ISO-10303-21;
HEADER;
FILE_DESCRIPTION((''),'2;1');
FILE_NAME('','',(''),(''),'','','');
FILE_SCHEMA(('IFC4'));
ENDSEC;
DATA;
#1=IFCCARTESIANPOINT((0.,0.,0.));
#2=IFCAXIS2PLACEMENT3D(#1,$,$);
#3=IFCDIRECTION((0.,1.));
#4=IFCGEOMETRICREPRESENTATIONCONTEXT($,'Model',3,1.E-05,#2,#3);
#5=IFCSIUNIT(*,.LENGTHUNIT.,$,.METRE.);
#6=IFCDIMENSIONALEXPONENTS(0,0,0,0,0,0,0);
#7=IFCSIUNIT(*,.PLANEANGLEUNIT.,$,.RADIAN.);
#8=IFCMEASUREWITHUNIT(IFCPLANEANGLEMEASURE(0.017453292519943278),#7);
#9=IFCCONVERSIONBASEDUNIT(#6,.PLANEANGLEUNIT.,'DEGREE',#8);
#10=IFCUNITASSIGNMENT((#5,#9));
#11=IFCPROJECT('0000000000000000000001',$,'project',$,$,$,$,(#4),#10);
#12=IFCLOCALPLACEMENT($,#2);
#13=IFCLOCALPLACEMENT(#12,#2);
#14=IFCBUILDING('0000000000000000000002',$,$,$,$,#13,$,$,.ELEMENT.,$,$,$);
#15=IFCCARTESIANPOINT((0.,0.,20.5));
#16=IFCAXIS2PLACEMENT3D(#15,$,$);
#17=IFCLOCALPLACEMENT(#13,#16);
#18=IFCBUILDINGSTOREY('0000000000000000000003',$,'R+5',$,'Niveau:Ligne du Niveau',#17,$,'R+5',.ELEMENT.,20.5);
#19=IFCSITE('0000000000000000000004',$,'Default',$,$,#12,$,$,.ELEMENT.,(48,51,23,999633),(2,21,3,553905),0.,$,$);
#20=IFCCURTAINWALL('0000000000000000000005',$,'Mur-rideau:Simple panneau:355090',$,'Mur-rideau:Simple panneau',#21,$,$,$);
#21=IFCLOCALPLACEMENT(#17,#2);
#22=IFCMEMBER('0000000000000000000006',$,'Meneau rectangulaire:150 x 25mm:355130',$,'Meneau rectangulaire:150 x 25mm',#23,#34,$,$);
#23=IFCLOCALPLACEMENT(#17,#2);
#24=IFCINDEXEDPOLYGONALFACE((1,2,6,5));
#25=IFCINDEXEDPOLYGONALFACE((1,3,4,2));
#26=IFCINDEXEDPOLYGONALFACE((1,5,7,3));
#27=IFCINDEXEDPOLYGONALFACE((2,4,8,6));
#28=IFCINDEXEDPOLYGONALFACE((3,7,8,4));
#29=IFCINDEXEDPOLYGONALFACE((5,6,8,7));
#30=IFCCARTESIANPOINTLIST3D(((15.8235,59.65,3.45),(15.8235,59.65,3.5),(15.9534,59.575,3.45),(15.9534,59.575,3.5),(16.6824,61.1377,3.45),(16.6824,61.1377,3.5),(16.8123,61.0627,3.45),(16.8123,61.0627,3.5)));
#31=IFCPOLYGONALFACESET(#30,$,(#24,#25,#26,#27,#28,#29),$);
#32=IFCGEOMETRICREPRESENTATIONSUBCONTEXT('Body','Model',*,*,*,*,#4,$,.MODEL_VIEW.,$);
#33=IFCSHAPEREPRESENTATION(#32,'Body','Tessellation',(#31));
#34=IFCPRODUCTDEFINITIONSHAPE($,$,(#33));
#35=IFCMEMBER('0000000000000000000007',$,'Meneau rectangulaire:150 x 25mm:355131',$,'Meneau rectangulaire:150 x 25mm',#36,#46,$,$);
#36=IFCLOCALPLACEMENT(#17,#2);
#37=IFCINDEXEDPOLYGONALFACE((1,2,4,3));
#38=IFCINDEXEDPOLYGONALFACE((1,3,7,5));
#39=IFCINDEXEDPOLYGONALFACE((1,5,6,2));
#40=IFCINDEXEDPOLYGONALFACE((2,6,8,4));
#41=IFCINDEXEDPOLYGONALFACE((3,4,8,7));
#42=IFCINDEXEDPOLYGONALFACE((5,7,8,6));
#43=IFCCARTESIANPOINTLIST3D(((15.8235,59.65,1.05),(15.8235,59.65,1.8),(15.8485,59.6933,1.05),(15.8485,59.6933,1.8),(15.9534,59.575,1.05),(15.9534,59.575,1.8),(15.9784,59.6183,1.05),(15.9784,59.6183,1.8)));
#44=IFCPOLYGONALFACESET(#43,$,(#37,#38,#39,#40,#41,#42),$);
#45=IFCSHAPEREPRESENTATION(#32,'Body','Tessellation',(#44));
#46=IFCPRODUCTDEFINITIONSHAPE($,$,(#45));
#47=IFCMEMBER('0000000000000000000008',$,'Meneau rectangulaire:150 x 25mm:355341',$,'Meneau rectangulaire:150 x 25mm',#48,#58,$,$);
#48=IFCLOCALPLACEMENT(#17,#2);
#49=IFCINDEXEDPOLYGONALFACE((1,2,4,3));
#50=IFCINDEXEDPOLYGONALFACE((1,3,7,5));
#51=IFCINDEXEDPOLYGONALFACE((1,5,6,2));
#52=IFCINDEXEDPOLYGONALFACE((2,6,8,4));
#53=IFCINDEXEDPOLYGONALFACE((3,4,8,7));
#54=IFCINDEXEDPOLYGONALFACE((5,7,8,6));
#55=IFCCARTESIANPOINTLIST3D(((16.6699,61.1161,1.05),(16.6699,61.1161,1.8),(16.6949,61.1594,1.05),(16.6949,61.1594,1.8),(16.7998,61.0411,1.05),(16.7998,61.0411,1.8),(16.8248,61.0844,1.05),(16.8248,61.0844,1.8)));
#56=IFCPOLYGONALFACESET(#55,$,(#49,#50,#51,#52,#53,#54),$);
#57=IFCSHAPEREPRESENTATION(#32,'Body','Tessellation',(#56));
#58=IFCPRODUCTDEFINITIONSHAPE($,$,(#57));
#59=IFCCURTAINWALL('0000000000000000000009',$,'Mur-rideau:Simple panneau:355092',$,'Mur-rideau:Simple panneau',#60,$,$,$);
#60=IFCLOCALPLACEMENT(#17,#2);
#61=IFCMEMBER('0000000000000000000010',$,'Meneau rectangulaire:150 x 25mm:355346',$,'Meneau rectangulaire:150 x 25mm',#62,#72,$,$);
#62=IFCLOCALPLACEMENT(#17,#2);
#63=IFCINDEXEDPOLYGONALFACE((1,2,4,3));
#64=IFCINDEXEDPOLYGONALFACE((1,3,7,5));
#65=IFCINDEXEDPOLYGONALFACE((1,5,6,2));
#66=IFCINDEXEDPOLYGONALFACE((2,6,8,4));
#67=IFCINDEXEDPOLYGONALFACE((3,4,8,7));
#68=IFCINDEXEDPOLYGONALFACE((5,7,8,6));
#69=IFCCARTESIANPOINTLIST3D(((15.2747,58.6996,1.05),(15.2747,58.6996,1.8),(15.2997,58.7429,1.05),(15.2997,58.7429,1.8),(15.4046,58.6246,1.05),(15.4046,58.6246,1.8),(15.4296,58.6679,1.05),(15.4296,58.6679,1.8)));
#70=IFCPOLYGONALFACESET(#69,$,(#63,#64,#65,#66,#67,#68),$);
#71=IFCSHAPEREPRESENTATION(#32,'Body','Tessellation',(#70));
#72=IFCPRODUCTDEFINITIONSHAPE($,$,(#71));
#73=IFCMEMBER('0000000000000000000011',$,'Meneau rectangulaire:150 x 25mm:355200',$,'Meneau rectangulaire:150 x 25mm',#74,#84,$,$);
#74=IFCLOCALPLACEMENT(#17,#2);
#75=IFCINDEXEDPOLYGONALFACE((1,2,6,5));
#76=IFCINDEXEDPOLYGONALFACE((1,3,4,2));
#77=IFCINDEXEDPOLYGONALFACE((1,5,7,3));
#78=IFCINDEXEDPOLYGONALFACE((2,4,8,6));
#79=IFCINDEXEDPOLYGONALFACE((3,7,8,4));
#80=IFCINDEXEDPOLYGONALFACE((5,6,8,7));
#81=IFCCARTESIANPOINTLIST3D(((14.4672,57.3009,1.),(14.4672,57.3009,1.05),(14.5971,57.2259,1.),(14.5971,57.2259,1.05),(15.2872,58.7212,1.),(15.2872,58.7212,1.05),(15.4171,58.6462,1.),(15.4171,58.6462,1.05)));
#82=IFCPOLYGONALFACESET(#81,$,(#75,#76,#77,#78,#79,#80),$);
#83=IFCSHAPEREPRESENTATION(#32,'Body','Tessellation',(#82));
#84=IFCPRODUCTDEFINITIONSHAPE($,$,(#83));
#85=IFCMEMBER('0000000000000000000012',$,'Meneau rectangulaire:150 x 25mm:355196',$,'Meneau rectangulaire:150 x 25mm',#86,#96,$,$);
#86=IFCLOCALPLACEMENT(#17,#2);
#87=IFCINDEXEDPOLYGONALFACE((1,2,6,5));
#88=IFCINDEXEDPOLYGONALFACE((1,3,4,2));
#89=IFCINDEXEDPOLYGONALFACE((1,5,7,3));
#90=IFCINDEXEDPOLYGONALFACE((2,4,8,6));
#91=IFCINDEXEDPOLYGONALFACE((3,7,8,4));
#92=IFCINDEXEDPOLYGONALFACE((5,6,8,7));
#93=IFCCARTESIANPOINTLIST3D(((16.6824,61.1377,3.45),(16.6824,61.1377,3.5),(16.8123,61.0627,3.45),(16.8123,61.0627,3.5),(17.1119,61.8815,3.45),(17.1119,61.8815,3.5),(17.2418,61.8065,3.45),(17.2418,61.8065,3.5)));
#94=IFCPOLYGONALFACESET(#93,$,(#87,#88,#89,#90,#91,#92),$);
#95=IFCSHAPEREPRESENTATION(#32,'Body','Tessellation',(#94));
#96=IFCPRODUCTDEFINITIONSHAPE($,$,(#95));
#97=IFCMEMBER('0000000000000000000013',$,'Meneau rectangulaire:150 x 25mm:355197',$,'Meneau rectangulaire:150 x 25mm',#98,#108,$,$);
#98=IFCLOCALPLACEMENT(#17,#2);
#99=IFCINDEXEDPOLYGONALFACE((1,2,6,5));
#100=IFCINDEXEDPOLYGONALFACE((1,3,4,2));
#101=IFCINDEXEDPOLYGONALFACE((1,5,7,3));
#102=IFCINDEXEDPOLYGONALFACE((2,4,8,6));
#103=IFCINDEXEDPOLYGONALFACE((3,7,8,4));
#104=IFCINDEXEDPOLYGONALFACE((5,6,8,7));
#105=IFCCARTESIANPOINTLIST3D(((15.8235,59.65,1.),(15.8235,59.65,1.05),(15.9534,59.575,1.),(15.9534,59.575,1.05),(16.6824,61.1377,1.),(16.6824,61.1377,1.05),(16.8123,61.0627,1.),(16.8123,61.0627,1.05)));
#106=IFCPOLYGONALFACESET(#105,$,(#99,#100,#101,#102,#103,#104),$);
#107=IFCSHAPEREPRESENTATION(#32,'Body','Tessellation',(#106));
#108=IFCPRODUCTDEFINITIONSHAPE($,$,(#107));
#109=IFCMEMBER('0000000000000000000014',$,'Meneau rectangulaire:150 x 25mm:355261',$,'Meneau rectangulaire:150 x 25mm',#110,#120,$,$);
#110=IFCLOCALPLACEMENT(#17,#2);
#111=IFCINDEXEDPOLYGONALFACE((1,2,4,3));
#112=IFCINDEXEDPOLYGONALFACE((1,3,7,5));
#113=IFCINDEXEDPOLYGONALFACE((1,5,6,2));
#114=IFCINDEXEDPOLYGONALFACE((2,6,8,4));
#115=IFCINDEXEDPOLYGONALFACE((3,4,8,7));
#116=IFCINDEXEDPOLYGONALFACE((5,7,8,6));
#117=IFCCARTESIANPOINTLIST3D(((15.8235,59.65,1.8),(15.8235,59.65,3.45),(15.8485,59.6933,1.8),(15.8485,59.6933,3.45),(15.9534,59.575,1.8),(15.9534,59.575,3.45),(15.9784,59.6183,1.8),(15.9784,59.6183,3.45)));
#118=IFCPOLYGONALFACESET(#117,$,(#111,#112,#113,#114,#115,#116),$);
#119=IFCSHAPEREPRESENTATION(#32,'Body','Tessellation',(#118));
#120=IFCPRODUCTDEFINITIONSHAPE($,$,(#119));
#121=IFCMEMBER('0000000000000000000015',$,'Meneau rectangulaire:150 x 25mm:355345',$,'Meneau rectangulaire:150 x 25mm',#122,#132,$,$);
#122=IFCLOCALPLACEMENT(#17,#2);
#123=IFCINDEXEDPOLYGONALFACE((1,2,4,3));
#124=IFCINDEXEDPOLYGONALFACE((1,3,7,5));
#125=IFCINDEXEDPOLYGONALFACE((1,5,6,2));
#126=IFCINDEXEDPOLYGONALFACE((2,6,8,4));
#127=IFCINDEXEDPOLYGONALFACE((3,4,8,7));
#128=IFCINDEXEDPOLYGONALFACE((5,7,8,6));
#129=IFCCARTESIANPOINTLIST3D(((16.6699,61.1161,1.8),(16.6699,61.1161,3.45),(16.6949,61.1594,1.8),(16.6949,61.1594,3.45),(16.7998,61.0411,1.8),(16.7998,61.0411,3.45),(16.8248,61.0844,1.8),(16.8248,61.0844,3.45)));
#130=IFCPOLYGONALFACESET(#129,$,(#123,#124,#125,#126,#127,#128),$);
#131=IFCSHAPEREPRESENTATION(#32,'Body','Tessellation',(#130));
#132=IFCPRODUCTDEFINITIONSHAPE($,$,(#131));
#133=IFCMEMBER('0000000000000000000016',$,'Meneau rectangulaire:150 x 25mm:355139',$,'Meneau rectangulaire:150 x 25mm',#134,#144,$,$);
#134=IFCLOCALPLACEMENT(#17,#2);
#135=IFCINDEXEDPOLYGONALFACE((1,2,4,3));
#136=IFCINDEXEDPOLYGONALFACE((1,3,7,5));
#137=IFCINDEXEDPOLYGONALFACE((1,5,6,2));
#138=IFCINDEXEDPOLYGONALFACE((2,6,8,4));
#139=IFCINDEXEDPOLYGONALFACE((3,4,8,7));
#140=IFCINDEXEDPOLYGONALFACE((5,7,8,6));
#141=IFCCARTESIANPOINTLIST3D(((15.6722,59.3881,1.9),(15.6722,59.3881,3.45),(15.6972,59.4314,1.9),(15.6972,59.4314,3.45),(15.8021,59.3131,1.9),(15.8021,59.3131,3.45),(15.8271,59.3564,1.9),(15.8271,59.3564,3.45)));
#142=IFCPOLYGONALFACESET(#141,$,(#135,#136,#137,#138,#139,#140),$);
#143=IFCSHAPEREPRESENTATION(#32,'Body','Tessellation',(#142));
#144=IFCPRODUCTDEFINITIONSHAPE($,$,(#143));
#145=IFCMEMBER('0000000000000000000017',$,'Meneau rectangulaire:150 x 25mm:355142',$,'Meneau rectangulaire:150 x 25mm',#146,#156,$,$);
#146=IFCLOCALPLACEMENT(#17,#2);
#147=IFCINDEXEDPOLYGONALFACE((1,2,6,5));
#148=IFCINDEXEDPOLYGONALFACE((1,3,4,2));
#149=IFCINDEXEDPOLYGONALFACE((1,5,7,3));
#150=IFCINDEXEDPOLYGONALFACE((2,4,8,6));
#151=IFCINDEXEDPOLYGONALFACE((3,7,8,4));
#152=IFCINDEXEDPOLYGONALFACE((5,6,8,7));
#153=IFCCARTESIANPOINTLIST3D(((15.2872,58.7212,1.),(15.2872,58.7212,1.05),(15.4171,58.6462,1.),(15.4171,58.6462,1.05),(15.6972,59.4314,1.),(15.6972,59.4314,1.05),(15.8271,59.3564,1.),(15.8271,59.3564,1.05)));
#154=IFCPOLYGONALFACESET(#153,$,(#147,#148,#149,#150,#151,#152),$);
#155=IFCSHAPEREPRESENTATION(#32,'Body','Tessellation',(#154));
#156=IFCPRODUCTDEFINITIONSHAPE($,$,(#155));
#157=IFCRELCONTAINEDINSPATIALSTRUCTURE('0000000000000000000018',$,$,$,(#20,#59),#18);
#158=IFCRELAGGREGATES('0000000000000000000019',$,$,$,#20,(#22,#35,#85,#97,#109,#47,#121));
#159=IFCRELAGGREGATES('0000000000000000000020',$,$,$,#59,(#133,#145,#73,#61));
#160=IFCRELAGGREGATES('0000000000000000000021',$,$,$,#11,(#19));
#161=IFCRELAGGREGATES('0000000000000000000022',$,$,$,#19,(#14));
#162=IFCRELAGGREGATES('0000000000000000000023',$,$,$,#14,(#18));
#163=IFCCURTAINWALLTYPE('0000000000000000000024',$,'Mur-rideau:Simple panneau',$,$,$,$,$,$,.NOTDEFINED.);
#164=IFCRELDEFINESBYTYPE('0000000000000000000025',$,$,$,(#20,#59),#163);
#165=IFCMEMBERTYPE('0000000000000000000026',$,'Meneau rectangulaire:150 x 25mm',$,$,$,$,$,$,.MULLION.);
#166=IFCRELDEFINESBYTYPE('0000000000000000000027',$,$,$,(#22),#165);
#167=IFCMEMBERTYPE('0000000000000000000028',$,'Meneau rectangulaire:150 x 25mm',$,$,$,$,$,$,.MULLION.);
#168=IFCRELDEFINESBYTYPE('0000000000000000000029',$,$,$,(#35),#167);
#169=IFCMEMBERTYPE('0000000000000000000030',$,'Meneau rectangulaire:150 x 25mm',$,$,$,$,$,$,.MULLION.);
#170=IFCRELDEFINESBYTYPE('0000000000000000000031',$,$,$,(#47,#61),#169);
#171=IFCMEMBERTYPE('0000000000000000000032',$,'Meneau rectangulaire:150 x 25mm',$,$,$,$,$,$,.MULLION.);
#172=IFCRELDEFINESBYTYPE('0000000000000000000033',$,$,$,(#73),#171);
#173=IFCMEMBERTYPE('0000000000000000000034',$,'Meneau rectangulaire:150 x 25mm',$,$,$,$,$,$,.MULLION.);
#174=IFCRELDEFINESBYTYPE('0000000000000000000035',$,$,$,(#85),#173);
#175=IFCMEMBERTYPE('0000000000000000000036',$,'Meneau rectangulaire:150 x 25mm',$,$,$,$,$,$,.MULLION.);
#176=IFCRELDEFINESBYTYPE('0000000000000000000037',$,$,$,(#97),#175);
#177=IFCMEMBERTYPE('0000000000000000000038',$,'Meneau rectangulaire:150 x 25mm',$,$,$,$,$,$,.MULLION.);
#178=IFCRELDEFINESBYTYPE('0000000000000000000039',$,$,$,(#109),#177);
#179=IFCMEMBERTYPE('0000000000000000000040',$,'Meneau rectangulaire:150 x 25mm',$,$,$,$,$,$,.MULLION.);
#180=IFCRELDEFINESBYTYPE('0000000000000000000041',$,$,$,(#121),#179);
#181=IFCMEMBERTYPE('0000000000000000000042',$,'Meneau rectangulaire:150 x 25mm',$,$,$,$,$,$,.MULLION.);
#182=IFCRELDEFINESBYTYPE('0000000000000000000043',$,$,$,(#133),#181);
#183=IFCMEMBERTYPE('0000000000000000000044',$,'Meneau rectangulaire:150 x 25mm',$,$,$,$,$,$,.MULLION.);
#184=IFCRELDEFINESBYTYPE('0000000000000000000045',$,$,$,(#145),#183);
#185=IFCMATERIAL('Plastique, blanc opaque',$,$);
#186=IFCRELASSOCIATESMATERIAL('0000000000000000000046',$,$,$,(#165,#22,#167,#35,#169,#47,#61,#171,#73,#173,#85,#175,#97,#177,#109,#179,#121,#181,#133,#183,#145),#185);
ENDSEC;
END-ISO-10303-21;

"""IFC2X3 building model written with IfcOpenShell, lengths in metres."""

from ifc_helpers import new_model, entity, si_unit, converted_unit, direction, frame, frame_2d, origin, origin_2d_with_axis, place, context, subcontext, project, spatial, rectangle, extrude, source, transform, mapped, material, type_object, type_shapes, element, aggregate, save


model = new_model("IFC2X3")

# Units and contexts
model_context = context("Model", 3, precision=1e-05, world=origin(), true_north=direction((0.0, 1.0)))
body_context = subcontext(model_context, "Body", "Model", "MODEL_VIEW")
ifc_project = project(units=[si_unit("LENGTHUNIT", "METRE"), converted_unit("PLANEANGLEUNIT", "DEGREE", entity("IfcPlaneAngleMeasure", 0.017453292519943278), si_unit("PLANEANGLEUNIT", "RADIAN"), dimensions=[0, 0, 0, 0, 0, 0, 0])], contexts=[model_context])

# Site, building, storey
site_placement = place(None, origin())
site = spatial("IfcSite", under=ifc_project, at=site_placement, Name="Default", CompositionType="ELEMENT", RefLatitude=(48, 51, 23, 999633), RefLongitude=(2, 21, 3, 553905), RefElevation=0.0)
building_placement = place(site_placement, origin())
building = spatial("IfcBuilding", under=site, at=building_placement, CompositionType="ELEMENT")
storey_placement = place(building_placement, frame((0.0, 0.0, 20.5)))
storey = spatial("IfcBuildingStorey", under=building, at=storey_placement, Name="R+5", ObjectType="Niveau:Ligne du Niveau", LongName="R+5", CompositionType="ELEMENT", Elevation=20.5)

# Curtain walls, members
curtain_wall_type = type_object("IfcCurtainWallType", Name="Mur-rideau:Simple panneau", PredefinedType="NOTDEFINED")
curtain_wall_1_placement = place(storey_placement, frame((0.0, 0.0, -20.5)))
curtain_wall_1 = element("IfcCurtainWall", 1, at=curtain_wall_1_placement, inside=storey, type_object=curtain_wall_type, Name="Mur-rideau:Simple panneau:355090", ObjectType="Mur-rideau:Simple panneau")
ifc_material_1 = material(Name="Plastique, blanc opaque")
member_type_1 = type_object("IfcMemberType", Name="Meneau rectangulaire:150 x 25mm", PredefinedType="MULLION", material=ifc_material_1)
shared_shape_1 = source(origin(), body_context, "Body", "SweptSolid", [
    extrude(rectangle(XDim=0.05, YDim=0.15, at=frame_2d((0.0, 0.0), x_axis=(1.0, 0.0))), frame((-0.025, 0.0, -1.7178), z_axis=(0.0, 0.0, 1.0), x_axis=(-1.0, 0.0, 0.0)), (0.0, 0.0, 1.0), 1.7178),
])
type_shapes(member_type_1, [shared_shape_1])
member_1_placement = place(curtain_wall_1_placement, frame((15.8884, 59.6125, 24.0), z_axis=(-0.5, -0.866025, 0.0), x_axis=(0.0, 0.0, 1.0)))
member_1 = element("IfcMember", 2, at=member_1_placement, type_object=member_type_1, material=ifc_material_1, Name="Meneau rectangulaire:150 x 25mm:355130", ObjectType="Meneau rectangulaire:150 x 25mm", context=body_context, shape_type="MappedRepresentation", body=[
    mapped(shared_shape_1, transform((0.0, 0.0, 0.0), scale=1.0)),
])
member_type_2 = type_object("IfcMemberType", Name="Meneau rectangulaire:150 x 25mm", PredefinedType="MULLION", material=ifc_material_1)
shared_shape_2 = source(origin(), body_context, "Body", "SweptSolid", [
    extrude(rectangle(XDim=0.05, YDim=0.15, at=origin_2d_with_axis()), frame((-0.025, 0.0, -0.75), z_axis=(0.0, 0.0, 1.0), x_axis=(-1.0, 0.0, 0.0)), (0.0, 0.0, 1.0), 0.75),
])
type_shapes(member_type_2, [shared_shape_2])
member_2_placement = place(curtain_wall_1_placement, frame((15.8884, 59.6125, 21.55), z_axis=(0.0, 0.0, -1.0), x_axis=(-0.5, -0.866025, 0.0)))
member_2 = element("IfcMember", 3, at=member_2_placement, type_object=member_type_2, material=ifc_material_1, Name="Meneau rectangulaire:150 x 25mm:355131", ObjectType="Meneau rectangulaire:150 x 25mm", context=body_context, shape_type="MappedRepresentation", body=[
    mapped(shared_shape_2, transform((0.0, 0.0, 0.0), scale=1.0)),
])
member_type_3 = type_object("IfcMemberType", Name="Meneau rectangulaire:150 x 25mm", PredefinedType="MULLION", material=ifc_material_1)
shared_shape_3 = source(origin(), body_context, "Body", "SweptSolid", [
    extrude(rectangle(XDim=0.05, YDim=0.15, at=origin_2d_with_axis()), frame((0.0, 0.0, -0.75), z_axis=(0.0, 0.0, 1.0), x_axis=(-1.0, 0.0, 0.0)), (0.0, 0.0, 1.0), 0.75),
])
type_shapes(member_type_3, [shared_shape_3])
member_3_placement = place(curtain_wall_1_placement, frame((16.7474, 61.1002, 21.55), z_axis=(0.0, 0.0, -1.0), x_axis=(-0.5, -0.866025, 0.0)))
member_3 = element("IfcMember", 4, at=member_3_placement, type_object=member_type_3, material=ifc_material_1, Name="Meneau rectangulaire:150 x 25mm:355341", ObjectType="Meneau rectangulaire:150 x 25mm", context=body_context, shape_type="MappedRepresentation", body=[
    mapped(shared_shape_3, transform((0.0, 0.0, 0.0), scale=1.0)),
])
curtain_wall_2_placement = place(storey_placement, frame((0.0, 0.0, -20.5)))
curtain_wall_2 = element("IfcCurtainWall", 5, at=curtain_wall_2_placement, inside=storey, type_object=curtain_wall_type, Name="Mur-rideau:Simple panneau:355092", ObjectType="Mur-rideau:Simple panneau")
member_4_placement = place(curtain_wall_2_placement, frame((15.3522, 58.6837, 21.55), z_axis=(0.0, 0.0, -1.0), x_axis=(-0.5, -0.866025, 0.0)))
member_4 = element("IfcMember", 6, at=member_4_placement, type_object=member_type_3, material=ifc_material_1, Name="Meneau rectangulaire:150 x 25mm:355346", ObjectType="Meneau rectangulaire:150 x 25mm", context=body_context, shape_type="MappedRepresentation", body=[
    mapped(shared_shape_3, transform((0.0, 0.0, 0.0), scale=1.0)),
])
member_type_4 = type_object("IfcMemberType", Name="Meneau rectangulaire:150 x 25mm", PredefinedType="MULLION", material=ifc_material_1)
shared_shape_4 = source(origin(), body_context, "Body", "SweptSolid", [
    extrude(rectangle(XDim=0.05, YDim=0.15, at=origin_2d_with_axis()), frame((-0.025, 0.0, -1.64), z_axis=(0.0, 0.0, 1.0), x_axis=(-1.0, 0.0, 0.0)), (0.0, 0.0, 1.0), 1.64),
])
type_shapes(member_type_4, [shared_shape_4])
member_5_placement = place(curtain_wall_2_placement, frame((15.3522, 58.6837, 21.5), z_axis=(0.5, 0.866025, 0.0), x_axis=(0.0, 0.0, -1.0)))
member_5 = element("IfcMember", 7, at=member_5_placement, type_object=member_type_4, material=ifc_material_1, Name="Meneau rectangulaire:150 x 25mm:355200", ObjectType="Meneau rectangulaire:150 x 25mm", context=body_context, shape_type="MappedRepresentation", body=[
    mapped(shared_shape_4, transform((0.0, 0.0, 0.0), scale=1.0)),
])

# Members
member_type_5 = type_object("IfcMemberType", Name="Meneau rectangulaire:150 x 25mm", PredefinedType="MULLION", material=ifc_material_1)
shared_shape_5 = source(origin(), body_context, "Body", "SweptSolid", [
    extrude(rectangle(XDim=0.05, YDim=0.15, at=origin_2d_with_axis()), frame((-0.025, 0.0, -0.8589), z_axis=(0.0, 0.0, 1.0), x_axis=(-1.0, 0.0, 0.0)), (0.0, 0.0, 1.0), 0.8589),
])
type_shapes(member_type_5, [shared_shape_5])
member_6_placement = place(curtain_wall_1_placement, frame((16.7474, 61.1002, 24.0), z_axis=(-0.5, -0.866025, 0.0), x_axis=(0.0, 0.0, 1.0)))
member_6 = element("IfcMember", 8, at=member_6_placement, type_object=member_type_5, material=ifc_material_1, Name="Meneau rectangulaire:150 x 25mm:355196", ObjectType="Meneau rectangulaire:150 x 25mm", context=body_context, shape_type="MappedRepresentation", body=[
    mapped(shared_shape_5, transform((0.0, 0.0, 0.0), scale=1.0)),
])
member_type_6 = type_object("IfcMemberType", Name="Meneau rectangulaire:150 x 25mm", PredefinedType="MULLION", material=ifc_material_1)
shared_shape_6 = source(origin(), body_context, "Body", "SweptSolid", [
    extrude(rectangle(XDim=0.05, YDim=0.15, at=origin_2d_with_axis()), frame((-0.025, 0.0, -1.7178), z_axis=(0.0, 0.0, 1.0), x_axis=(-1.0, 0.0, 0.0)), (0.0, 0.0, 1.0), 1.7178),
])
type_shapes(member_type_6, [shared_shape_6])
member_7_placement = place(curtain_wall_1_placement, frame((16.7474, 61.1002, 21.5), z_axis=(0.5, 0.866025, 0.0), x_axis=(0.0, 0.0, -1.0)))
member_7 = element("IfcMember", 9, at=member_7_placement, type_object=member_type_6, material=ifc_material_1, Name="Meneau rectangulaire:150 x 25mm:355197", ObjectType="Meneau rectangulaire:150 x 25mm", context=body_context, shape_type="MappedRepresentation", body=[
    mapped(shared_shape_6, transform((0.0, 0.0, 0.0), scale=1.0)),
])
member_type_7 = type_object("IfcMemberType", Name="Meneau rectangulaire:150 x 25mm", PredefinedType="MULLION", material=ifc_material_1)
shared_shape_7 = source(origin(), body_context, "Body", "SweptSolid", [
    extrude(rectangle(XDim=0.05, YDim=0.15, at=origin_2d_with_axis()), frame((-0.025, 0.0, -1.65), z_axis=(0.0, 0.0, 1.0), x_axis=(-1.0, 0.0, 0.0)), (0.0, 0.0, 1.0), 1.65),
])
type_shapes(member_type_7, [shared_shape_7])
member_8_placement = place(curtain_wall_1_placement, frame((15.8884, 59.6125, 22.3), z_axis=(0.0, 0.0, -1.0), x_axis=(-0.5, -0.866025, 0.0)))
member_8 = element("IfcMember", 10, at=member_8_placement, type_object=member_type_7, material=ifc_material_1, Name="Meneau rectangulaire:150 x 25mm:355261", ObjectType="Meneau rectangulaire:150 x 25mm", context=body_context, shape_type="MappedRepresentation", body=[
    mapped(shared_shape_7, transform((0.0, 0.0, 0.0), scale=1.0)),
])
member_type_8 = type_object("IfcMemberType", Name="Meneau rectangulaire:150 x 25mm", PredefinedType="MULLION", material=ifc_material_1)
shared_shape_8 = source(origin(), body_context, "Body", "SweptSolid", [
    extrude(rectangle(XDim=0.05, YDim=0.15, at=origin_2d_with_axis()), frame((0.0, 0.0, -1.65), z_axis=(0.0, 0.0, 1.0), x_axis=(-1.0, 0.0, 0.0)), (0.0, 0.0, 1.0), 1.65),
])
type_shapes(member_type_8, [shared_shape_8])
member_9_placement = place(curtain_wall_1_placement, frame((16.7474, 61.1002, 22.3), z_axis=(0.0, 0.0, -1.0), x_axis=(-0.5, -0.866025, 0.0)))
member_9 = element("IfcMember", 11, at=member_9_placement, type_object=member_type_8, material=ifc_material_1, Name="Meneau rectangulaire:150 x 25mm:355345", ObjectType="Meneau rectangulaire:150 x 25mm", context=body_context, shape_type="MappedRepresentation", body=[
    mapped(shared_shape_8, transform((0.0, 0.0, 0.0), scale=1.0)),
])
member_type_9 = type_object("IfcMemberType", Name="Meneau rectangulaire:150 x 25mm", PredefinedType="MULLION", material=ifc_material_1)
shared_shape_9 = source(origin(), body_context, "Body", "SweptSolid", [
    extrude(rectangle(XDim=0.05, YDim=0.15, at=origin_2d_with_axis()), frame((-0.025, 0.0, -1.55), z_axis=(0.0, 0.0, 1.0), x_axis=(-1.0, 0.0, 0.0)), (0.0, 0.0, 1.0), 1.55),
])
type_shapes(member_type_9, [shared_shape_9])
member_10_placement = place(curtain_wall_2_placement, frame((15.7622, 59.3939, 23.95), z_axis=(0.0, 0.0, 1.0), x_axis=(0.5, 0.866025, 0.0)))
member_10 = element("IfcMember", 12, at=member_10_placement, type_object=member_type_9, material=ifc_material_1, Name="Meneau rectangulaire:150 x 25mm:355139", ObjectType="Meneau rectangulaire:150 x 25mm", context=body_context, shape_type="MappedRepresentation", body=[
    mapped(shared_shape_9, transform((0.0, 0.0, 0.0), scale=1.0)),
])
member_type_10 = type_object("IfcMemberType", Name="Meneau rectangulaire:150 x 25mm", PredefinedType="MULLION", material=ifc_material_1)
shared_shape_10 = source(origin(), body_context, "Body", "SweptSolid", [
    extrude(rectangle(XDim=0.05, YDim=0.15, at=origin_2d_with_axis()), frame((-0.025, 0.0, -0.82), z_axis=(0.0, 0.0, 1.0), x_axis=(-1.0, 0.0, 0.0)), (0.0, 0.0, 1.0), 0.82),
])
type_shapes(member_type_10, [shared_shape_10])
member_11_placement = place(curtain_wall_2_placement, frame((15.7622, 59.3939, 21.5), z_axis=(0.5, 0.866025, 0.0), x_axis=(0.0, 0.0, -1.0)))
member_11 = element("IfcMember", 13, at=member_11_placement, type_object=member_type_10, material=ifc_material_1, Name="Meneau rectangulaire:150 x 25mm:355142", ObjectType="Meneau rectangulaire:150 x 25mm", context=body_context, shape_type="MappedRepresentation", body=[
    mapped(shared_shape_10, transform((0.0, 0.0, 0.0), scale=1.0)),
])

aggregate(curtain_wall_1, [member_1, member_2, member_6, member_7, member_8, member_3, member_9])
aggregate(curtain_wall_2, [member_10, member_11, member_5, member_4])

save(model, "model.ifc")
